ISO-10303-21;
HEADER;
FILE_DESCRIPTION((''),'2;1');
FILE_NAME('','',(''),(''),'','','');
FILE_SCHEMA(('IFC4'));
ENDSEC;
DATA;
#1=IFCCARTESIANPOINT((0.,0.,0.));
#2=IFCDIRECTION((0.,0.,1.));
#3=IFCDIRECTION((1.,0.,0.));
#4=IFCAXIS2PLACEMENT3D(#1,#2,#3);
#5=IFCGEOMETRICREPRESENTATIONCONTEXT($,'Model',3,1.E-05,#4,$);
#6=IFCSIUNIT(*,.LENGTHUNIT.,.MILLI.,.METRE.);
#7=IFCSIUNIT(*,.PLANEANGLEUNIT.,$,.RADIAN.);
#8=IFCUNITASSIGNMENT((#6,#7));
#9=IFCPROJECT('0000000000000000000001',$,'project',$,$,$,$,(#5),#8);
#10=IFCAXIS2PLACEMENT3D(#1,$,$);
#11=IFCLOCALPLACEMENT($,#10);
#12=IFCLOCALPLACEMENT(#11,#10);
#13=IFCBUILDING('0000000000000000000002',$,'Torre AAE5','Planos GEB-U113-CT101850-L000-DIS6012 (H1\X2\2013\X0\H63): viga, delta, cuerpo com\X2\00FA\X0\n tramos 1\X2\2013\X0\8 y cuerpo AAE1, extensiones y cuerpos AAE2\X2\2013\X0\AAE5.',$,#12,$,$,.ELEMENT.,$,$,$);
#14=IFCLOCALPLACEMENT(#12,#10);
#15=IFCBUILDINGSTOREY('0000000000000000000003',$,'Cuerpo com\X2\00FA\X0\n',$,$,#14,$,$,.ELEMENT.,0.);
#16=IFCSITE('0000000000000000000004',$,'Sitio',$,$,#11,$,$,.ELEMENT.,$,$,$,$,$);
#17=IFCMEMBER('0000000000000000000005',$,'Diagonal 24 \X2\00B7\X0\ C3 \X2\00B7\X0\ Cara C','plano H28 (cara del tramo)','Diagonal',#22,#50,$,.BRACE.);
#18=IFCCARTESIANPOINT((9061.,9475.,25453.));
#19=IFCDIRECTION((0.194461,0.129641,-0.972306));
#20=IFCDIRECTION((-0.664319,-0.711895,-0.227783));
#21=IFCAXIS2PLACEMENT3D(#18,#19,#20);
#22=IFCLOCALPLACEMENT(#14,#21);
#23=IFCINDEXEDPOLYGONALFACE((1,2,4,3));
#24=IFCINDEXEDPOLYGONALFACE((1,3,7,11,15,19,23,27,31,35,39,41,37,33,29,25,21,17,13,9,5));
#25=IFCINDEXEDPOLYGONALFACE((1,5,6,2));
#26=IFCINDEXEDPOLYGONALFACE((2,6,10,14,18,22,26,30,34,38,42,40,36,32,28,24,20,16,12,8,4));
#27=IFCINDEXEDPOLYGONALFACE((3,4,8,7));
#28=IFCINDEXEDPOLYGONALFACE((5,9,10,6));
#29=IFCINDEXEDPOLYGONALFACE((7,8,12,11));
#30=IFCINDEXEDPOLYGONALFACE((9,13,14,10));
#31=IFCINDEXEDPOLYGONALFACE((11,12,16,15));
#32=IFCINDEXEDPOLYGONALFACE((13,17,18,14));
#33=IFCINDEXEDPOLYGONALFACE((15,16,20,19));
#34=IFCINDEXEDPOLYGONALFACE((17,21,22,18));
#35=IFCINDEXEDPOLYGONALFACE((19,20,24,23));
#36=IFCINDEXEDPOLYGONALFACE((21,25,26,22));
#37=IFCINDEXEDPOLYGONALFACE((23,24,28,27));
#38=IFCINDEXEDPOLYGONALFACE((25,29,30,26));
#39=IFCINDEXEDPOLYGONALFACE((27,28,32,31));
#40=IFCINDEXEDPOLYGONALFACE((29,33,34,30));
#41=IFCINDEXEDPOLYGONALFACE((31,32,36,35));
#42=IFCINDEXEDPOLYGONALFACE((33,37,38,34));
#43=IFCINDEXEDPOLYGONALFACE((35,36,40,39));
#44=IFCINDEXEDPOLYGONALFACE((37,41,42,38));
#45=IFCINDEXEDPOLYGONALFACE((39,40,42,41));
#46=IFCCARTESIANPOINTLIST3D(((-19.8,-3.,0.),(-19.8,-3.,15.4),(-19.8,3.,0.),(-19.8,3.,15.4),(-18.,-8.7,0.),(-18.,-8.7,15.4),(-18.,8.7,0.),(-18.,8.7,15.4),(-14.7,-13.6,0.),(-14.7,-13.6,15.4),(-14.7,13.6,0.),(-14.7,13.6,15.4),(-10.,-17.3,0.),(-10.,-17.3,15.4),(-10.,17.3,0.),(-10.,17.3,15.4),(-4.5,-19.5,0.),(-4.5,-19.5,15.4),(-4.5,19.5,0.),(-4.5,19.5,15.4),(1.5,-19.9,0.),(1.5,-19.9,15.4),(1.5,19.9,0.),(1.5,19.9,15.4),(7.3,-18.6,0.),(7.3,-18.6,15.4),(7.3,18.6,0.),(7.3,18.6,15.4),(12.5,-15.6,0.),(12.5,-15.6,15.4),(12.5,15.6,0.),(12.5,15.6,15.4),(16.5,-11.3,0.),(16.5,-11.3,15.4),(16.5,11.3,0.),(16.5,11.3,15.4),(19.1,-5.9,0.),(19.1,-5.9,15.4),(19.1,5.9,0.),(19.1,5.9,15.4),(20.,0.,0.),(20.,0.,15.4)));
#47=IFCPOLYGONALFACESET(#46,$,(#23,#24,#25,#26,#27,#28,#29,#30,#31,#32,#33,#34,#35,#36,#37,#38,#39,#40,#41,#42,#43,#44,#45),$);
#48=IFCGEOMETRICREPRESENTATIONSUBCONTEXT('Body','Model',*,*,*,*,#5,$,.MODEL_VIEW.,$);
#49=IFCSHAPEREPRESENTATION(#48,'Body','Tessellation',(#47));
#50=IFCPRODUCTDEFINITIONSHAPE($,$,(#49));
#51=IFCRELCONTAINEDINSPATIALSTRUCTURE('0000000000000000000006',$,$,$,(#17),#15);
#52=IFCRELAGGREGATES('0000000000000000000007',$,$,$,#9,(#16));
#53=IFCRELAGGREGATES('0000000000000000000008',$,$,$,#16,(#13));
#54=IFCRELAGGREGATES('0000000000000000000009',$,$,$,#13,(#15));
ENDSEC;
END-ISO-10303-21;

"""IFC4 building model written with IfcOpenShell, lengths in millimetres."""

from ifc_helpers import new_model, si_unit, frame, origin, origin_with_axes, place, context, subcontext, project, spatial, circle, extrude, element, save


model = new_model("IFC4")

# Units and contexts
model_context = context("Model", 3, precision=1e-05, world=origin_with_axes())
body_context = subcontext(model_context, "Body", "Model", "MODEL_VIEW")
ifc_project = project(units=[si_unit("LENGTHUNIT", "METRE", prefix="MILLI"), si_unit("PLANEANGLEUNIT", "RADIAN")], contexts=[model_context])

# Site, building, storey
site_placement = place(None, origin())
site = spatial("IfcSite", under=ifc_project, at=site_placement, Name="Sitio", CompositionType="ELEMENT")
building_placement = place(site_placement, origin())
building = spatial("IfcBuilding", under=site, at=building_placement, Name="Torre AAE5", Description="Planos GEB-U113-CT101850-L000-DIS6012 (H1–H63): viga, delta, cuerpo común tramos 1–8 y cuerpo AAE1, extensiones y cuerpos AAE2–AAE5.", CompositionType="ELEMENT")
storey_placement = place(building_placement, origin())
storey = spatial("IfcBuildingStorey", under=building, at=storey_placement, Name="Cuerpo común", CompositionType="ELEMENT", Elevation=0.0)

# Member
member_1_placement = place(storey_placement, frame((9061.0, 9475.0, 25453.0), z_axis=(0.194461, 0.129641, -0.972306), x_axis=(-0.664319, -0.711895, -0.227783)))
element("IfcMember", 1, at=member_1_placement, inside=storey, Name="Diagonal 24 · C3 · Cara C", Description="plano H28 (cara del tramo)", ObjectType="Diagonal", PredefinedType="BRACE", context=body_context, shape_type="SweptSolid", body=[
    extrude(circle(Radius=20.0), None, (0.0, 0.0, 1.0), 15.4),
])

save(model, "model.ifc")
